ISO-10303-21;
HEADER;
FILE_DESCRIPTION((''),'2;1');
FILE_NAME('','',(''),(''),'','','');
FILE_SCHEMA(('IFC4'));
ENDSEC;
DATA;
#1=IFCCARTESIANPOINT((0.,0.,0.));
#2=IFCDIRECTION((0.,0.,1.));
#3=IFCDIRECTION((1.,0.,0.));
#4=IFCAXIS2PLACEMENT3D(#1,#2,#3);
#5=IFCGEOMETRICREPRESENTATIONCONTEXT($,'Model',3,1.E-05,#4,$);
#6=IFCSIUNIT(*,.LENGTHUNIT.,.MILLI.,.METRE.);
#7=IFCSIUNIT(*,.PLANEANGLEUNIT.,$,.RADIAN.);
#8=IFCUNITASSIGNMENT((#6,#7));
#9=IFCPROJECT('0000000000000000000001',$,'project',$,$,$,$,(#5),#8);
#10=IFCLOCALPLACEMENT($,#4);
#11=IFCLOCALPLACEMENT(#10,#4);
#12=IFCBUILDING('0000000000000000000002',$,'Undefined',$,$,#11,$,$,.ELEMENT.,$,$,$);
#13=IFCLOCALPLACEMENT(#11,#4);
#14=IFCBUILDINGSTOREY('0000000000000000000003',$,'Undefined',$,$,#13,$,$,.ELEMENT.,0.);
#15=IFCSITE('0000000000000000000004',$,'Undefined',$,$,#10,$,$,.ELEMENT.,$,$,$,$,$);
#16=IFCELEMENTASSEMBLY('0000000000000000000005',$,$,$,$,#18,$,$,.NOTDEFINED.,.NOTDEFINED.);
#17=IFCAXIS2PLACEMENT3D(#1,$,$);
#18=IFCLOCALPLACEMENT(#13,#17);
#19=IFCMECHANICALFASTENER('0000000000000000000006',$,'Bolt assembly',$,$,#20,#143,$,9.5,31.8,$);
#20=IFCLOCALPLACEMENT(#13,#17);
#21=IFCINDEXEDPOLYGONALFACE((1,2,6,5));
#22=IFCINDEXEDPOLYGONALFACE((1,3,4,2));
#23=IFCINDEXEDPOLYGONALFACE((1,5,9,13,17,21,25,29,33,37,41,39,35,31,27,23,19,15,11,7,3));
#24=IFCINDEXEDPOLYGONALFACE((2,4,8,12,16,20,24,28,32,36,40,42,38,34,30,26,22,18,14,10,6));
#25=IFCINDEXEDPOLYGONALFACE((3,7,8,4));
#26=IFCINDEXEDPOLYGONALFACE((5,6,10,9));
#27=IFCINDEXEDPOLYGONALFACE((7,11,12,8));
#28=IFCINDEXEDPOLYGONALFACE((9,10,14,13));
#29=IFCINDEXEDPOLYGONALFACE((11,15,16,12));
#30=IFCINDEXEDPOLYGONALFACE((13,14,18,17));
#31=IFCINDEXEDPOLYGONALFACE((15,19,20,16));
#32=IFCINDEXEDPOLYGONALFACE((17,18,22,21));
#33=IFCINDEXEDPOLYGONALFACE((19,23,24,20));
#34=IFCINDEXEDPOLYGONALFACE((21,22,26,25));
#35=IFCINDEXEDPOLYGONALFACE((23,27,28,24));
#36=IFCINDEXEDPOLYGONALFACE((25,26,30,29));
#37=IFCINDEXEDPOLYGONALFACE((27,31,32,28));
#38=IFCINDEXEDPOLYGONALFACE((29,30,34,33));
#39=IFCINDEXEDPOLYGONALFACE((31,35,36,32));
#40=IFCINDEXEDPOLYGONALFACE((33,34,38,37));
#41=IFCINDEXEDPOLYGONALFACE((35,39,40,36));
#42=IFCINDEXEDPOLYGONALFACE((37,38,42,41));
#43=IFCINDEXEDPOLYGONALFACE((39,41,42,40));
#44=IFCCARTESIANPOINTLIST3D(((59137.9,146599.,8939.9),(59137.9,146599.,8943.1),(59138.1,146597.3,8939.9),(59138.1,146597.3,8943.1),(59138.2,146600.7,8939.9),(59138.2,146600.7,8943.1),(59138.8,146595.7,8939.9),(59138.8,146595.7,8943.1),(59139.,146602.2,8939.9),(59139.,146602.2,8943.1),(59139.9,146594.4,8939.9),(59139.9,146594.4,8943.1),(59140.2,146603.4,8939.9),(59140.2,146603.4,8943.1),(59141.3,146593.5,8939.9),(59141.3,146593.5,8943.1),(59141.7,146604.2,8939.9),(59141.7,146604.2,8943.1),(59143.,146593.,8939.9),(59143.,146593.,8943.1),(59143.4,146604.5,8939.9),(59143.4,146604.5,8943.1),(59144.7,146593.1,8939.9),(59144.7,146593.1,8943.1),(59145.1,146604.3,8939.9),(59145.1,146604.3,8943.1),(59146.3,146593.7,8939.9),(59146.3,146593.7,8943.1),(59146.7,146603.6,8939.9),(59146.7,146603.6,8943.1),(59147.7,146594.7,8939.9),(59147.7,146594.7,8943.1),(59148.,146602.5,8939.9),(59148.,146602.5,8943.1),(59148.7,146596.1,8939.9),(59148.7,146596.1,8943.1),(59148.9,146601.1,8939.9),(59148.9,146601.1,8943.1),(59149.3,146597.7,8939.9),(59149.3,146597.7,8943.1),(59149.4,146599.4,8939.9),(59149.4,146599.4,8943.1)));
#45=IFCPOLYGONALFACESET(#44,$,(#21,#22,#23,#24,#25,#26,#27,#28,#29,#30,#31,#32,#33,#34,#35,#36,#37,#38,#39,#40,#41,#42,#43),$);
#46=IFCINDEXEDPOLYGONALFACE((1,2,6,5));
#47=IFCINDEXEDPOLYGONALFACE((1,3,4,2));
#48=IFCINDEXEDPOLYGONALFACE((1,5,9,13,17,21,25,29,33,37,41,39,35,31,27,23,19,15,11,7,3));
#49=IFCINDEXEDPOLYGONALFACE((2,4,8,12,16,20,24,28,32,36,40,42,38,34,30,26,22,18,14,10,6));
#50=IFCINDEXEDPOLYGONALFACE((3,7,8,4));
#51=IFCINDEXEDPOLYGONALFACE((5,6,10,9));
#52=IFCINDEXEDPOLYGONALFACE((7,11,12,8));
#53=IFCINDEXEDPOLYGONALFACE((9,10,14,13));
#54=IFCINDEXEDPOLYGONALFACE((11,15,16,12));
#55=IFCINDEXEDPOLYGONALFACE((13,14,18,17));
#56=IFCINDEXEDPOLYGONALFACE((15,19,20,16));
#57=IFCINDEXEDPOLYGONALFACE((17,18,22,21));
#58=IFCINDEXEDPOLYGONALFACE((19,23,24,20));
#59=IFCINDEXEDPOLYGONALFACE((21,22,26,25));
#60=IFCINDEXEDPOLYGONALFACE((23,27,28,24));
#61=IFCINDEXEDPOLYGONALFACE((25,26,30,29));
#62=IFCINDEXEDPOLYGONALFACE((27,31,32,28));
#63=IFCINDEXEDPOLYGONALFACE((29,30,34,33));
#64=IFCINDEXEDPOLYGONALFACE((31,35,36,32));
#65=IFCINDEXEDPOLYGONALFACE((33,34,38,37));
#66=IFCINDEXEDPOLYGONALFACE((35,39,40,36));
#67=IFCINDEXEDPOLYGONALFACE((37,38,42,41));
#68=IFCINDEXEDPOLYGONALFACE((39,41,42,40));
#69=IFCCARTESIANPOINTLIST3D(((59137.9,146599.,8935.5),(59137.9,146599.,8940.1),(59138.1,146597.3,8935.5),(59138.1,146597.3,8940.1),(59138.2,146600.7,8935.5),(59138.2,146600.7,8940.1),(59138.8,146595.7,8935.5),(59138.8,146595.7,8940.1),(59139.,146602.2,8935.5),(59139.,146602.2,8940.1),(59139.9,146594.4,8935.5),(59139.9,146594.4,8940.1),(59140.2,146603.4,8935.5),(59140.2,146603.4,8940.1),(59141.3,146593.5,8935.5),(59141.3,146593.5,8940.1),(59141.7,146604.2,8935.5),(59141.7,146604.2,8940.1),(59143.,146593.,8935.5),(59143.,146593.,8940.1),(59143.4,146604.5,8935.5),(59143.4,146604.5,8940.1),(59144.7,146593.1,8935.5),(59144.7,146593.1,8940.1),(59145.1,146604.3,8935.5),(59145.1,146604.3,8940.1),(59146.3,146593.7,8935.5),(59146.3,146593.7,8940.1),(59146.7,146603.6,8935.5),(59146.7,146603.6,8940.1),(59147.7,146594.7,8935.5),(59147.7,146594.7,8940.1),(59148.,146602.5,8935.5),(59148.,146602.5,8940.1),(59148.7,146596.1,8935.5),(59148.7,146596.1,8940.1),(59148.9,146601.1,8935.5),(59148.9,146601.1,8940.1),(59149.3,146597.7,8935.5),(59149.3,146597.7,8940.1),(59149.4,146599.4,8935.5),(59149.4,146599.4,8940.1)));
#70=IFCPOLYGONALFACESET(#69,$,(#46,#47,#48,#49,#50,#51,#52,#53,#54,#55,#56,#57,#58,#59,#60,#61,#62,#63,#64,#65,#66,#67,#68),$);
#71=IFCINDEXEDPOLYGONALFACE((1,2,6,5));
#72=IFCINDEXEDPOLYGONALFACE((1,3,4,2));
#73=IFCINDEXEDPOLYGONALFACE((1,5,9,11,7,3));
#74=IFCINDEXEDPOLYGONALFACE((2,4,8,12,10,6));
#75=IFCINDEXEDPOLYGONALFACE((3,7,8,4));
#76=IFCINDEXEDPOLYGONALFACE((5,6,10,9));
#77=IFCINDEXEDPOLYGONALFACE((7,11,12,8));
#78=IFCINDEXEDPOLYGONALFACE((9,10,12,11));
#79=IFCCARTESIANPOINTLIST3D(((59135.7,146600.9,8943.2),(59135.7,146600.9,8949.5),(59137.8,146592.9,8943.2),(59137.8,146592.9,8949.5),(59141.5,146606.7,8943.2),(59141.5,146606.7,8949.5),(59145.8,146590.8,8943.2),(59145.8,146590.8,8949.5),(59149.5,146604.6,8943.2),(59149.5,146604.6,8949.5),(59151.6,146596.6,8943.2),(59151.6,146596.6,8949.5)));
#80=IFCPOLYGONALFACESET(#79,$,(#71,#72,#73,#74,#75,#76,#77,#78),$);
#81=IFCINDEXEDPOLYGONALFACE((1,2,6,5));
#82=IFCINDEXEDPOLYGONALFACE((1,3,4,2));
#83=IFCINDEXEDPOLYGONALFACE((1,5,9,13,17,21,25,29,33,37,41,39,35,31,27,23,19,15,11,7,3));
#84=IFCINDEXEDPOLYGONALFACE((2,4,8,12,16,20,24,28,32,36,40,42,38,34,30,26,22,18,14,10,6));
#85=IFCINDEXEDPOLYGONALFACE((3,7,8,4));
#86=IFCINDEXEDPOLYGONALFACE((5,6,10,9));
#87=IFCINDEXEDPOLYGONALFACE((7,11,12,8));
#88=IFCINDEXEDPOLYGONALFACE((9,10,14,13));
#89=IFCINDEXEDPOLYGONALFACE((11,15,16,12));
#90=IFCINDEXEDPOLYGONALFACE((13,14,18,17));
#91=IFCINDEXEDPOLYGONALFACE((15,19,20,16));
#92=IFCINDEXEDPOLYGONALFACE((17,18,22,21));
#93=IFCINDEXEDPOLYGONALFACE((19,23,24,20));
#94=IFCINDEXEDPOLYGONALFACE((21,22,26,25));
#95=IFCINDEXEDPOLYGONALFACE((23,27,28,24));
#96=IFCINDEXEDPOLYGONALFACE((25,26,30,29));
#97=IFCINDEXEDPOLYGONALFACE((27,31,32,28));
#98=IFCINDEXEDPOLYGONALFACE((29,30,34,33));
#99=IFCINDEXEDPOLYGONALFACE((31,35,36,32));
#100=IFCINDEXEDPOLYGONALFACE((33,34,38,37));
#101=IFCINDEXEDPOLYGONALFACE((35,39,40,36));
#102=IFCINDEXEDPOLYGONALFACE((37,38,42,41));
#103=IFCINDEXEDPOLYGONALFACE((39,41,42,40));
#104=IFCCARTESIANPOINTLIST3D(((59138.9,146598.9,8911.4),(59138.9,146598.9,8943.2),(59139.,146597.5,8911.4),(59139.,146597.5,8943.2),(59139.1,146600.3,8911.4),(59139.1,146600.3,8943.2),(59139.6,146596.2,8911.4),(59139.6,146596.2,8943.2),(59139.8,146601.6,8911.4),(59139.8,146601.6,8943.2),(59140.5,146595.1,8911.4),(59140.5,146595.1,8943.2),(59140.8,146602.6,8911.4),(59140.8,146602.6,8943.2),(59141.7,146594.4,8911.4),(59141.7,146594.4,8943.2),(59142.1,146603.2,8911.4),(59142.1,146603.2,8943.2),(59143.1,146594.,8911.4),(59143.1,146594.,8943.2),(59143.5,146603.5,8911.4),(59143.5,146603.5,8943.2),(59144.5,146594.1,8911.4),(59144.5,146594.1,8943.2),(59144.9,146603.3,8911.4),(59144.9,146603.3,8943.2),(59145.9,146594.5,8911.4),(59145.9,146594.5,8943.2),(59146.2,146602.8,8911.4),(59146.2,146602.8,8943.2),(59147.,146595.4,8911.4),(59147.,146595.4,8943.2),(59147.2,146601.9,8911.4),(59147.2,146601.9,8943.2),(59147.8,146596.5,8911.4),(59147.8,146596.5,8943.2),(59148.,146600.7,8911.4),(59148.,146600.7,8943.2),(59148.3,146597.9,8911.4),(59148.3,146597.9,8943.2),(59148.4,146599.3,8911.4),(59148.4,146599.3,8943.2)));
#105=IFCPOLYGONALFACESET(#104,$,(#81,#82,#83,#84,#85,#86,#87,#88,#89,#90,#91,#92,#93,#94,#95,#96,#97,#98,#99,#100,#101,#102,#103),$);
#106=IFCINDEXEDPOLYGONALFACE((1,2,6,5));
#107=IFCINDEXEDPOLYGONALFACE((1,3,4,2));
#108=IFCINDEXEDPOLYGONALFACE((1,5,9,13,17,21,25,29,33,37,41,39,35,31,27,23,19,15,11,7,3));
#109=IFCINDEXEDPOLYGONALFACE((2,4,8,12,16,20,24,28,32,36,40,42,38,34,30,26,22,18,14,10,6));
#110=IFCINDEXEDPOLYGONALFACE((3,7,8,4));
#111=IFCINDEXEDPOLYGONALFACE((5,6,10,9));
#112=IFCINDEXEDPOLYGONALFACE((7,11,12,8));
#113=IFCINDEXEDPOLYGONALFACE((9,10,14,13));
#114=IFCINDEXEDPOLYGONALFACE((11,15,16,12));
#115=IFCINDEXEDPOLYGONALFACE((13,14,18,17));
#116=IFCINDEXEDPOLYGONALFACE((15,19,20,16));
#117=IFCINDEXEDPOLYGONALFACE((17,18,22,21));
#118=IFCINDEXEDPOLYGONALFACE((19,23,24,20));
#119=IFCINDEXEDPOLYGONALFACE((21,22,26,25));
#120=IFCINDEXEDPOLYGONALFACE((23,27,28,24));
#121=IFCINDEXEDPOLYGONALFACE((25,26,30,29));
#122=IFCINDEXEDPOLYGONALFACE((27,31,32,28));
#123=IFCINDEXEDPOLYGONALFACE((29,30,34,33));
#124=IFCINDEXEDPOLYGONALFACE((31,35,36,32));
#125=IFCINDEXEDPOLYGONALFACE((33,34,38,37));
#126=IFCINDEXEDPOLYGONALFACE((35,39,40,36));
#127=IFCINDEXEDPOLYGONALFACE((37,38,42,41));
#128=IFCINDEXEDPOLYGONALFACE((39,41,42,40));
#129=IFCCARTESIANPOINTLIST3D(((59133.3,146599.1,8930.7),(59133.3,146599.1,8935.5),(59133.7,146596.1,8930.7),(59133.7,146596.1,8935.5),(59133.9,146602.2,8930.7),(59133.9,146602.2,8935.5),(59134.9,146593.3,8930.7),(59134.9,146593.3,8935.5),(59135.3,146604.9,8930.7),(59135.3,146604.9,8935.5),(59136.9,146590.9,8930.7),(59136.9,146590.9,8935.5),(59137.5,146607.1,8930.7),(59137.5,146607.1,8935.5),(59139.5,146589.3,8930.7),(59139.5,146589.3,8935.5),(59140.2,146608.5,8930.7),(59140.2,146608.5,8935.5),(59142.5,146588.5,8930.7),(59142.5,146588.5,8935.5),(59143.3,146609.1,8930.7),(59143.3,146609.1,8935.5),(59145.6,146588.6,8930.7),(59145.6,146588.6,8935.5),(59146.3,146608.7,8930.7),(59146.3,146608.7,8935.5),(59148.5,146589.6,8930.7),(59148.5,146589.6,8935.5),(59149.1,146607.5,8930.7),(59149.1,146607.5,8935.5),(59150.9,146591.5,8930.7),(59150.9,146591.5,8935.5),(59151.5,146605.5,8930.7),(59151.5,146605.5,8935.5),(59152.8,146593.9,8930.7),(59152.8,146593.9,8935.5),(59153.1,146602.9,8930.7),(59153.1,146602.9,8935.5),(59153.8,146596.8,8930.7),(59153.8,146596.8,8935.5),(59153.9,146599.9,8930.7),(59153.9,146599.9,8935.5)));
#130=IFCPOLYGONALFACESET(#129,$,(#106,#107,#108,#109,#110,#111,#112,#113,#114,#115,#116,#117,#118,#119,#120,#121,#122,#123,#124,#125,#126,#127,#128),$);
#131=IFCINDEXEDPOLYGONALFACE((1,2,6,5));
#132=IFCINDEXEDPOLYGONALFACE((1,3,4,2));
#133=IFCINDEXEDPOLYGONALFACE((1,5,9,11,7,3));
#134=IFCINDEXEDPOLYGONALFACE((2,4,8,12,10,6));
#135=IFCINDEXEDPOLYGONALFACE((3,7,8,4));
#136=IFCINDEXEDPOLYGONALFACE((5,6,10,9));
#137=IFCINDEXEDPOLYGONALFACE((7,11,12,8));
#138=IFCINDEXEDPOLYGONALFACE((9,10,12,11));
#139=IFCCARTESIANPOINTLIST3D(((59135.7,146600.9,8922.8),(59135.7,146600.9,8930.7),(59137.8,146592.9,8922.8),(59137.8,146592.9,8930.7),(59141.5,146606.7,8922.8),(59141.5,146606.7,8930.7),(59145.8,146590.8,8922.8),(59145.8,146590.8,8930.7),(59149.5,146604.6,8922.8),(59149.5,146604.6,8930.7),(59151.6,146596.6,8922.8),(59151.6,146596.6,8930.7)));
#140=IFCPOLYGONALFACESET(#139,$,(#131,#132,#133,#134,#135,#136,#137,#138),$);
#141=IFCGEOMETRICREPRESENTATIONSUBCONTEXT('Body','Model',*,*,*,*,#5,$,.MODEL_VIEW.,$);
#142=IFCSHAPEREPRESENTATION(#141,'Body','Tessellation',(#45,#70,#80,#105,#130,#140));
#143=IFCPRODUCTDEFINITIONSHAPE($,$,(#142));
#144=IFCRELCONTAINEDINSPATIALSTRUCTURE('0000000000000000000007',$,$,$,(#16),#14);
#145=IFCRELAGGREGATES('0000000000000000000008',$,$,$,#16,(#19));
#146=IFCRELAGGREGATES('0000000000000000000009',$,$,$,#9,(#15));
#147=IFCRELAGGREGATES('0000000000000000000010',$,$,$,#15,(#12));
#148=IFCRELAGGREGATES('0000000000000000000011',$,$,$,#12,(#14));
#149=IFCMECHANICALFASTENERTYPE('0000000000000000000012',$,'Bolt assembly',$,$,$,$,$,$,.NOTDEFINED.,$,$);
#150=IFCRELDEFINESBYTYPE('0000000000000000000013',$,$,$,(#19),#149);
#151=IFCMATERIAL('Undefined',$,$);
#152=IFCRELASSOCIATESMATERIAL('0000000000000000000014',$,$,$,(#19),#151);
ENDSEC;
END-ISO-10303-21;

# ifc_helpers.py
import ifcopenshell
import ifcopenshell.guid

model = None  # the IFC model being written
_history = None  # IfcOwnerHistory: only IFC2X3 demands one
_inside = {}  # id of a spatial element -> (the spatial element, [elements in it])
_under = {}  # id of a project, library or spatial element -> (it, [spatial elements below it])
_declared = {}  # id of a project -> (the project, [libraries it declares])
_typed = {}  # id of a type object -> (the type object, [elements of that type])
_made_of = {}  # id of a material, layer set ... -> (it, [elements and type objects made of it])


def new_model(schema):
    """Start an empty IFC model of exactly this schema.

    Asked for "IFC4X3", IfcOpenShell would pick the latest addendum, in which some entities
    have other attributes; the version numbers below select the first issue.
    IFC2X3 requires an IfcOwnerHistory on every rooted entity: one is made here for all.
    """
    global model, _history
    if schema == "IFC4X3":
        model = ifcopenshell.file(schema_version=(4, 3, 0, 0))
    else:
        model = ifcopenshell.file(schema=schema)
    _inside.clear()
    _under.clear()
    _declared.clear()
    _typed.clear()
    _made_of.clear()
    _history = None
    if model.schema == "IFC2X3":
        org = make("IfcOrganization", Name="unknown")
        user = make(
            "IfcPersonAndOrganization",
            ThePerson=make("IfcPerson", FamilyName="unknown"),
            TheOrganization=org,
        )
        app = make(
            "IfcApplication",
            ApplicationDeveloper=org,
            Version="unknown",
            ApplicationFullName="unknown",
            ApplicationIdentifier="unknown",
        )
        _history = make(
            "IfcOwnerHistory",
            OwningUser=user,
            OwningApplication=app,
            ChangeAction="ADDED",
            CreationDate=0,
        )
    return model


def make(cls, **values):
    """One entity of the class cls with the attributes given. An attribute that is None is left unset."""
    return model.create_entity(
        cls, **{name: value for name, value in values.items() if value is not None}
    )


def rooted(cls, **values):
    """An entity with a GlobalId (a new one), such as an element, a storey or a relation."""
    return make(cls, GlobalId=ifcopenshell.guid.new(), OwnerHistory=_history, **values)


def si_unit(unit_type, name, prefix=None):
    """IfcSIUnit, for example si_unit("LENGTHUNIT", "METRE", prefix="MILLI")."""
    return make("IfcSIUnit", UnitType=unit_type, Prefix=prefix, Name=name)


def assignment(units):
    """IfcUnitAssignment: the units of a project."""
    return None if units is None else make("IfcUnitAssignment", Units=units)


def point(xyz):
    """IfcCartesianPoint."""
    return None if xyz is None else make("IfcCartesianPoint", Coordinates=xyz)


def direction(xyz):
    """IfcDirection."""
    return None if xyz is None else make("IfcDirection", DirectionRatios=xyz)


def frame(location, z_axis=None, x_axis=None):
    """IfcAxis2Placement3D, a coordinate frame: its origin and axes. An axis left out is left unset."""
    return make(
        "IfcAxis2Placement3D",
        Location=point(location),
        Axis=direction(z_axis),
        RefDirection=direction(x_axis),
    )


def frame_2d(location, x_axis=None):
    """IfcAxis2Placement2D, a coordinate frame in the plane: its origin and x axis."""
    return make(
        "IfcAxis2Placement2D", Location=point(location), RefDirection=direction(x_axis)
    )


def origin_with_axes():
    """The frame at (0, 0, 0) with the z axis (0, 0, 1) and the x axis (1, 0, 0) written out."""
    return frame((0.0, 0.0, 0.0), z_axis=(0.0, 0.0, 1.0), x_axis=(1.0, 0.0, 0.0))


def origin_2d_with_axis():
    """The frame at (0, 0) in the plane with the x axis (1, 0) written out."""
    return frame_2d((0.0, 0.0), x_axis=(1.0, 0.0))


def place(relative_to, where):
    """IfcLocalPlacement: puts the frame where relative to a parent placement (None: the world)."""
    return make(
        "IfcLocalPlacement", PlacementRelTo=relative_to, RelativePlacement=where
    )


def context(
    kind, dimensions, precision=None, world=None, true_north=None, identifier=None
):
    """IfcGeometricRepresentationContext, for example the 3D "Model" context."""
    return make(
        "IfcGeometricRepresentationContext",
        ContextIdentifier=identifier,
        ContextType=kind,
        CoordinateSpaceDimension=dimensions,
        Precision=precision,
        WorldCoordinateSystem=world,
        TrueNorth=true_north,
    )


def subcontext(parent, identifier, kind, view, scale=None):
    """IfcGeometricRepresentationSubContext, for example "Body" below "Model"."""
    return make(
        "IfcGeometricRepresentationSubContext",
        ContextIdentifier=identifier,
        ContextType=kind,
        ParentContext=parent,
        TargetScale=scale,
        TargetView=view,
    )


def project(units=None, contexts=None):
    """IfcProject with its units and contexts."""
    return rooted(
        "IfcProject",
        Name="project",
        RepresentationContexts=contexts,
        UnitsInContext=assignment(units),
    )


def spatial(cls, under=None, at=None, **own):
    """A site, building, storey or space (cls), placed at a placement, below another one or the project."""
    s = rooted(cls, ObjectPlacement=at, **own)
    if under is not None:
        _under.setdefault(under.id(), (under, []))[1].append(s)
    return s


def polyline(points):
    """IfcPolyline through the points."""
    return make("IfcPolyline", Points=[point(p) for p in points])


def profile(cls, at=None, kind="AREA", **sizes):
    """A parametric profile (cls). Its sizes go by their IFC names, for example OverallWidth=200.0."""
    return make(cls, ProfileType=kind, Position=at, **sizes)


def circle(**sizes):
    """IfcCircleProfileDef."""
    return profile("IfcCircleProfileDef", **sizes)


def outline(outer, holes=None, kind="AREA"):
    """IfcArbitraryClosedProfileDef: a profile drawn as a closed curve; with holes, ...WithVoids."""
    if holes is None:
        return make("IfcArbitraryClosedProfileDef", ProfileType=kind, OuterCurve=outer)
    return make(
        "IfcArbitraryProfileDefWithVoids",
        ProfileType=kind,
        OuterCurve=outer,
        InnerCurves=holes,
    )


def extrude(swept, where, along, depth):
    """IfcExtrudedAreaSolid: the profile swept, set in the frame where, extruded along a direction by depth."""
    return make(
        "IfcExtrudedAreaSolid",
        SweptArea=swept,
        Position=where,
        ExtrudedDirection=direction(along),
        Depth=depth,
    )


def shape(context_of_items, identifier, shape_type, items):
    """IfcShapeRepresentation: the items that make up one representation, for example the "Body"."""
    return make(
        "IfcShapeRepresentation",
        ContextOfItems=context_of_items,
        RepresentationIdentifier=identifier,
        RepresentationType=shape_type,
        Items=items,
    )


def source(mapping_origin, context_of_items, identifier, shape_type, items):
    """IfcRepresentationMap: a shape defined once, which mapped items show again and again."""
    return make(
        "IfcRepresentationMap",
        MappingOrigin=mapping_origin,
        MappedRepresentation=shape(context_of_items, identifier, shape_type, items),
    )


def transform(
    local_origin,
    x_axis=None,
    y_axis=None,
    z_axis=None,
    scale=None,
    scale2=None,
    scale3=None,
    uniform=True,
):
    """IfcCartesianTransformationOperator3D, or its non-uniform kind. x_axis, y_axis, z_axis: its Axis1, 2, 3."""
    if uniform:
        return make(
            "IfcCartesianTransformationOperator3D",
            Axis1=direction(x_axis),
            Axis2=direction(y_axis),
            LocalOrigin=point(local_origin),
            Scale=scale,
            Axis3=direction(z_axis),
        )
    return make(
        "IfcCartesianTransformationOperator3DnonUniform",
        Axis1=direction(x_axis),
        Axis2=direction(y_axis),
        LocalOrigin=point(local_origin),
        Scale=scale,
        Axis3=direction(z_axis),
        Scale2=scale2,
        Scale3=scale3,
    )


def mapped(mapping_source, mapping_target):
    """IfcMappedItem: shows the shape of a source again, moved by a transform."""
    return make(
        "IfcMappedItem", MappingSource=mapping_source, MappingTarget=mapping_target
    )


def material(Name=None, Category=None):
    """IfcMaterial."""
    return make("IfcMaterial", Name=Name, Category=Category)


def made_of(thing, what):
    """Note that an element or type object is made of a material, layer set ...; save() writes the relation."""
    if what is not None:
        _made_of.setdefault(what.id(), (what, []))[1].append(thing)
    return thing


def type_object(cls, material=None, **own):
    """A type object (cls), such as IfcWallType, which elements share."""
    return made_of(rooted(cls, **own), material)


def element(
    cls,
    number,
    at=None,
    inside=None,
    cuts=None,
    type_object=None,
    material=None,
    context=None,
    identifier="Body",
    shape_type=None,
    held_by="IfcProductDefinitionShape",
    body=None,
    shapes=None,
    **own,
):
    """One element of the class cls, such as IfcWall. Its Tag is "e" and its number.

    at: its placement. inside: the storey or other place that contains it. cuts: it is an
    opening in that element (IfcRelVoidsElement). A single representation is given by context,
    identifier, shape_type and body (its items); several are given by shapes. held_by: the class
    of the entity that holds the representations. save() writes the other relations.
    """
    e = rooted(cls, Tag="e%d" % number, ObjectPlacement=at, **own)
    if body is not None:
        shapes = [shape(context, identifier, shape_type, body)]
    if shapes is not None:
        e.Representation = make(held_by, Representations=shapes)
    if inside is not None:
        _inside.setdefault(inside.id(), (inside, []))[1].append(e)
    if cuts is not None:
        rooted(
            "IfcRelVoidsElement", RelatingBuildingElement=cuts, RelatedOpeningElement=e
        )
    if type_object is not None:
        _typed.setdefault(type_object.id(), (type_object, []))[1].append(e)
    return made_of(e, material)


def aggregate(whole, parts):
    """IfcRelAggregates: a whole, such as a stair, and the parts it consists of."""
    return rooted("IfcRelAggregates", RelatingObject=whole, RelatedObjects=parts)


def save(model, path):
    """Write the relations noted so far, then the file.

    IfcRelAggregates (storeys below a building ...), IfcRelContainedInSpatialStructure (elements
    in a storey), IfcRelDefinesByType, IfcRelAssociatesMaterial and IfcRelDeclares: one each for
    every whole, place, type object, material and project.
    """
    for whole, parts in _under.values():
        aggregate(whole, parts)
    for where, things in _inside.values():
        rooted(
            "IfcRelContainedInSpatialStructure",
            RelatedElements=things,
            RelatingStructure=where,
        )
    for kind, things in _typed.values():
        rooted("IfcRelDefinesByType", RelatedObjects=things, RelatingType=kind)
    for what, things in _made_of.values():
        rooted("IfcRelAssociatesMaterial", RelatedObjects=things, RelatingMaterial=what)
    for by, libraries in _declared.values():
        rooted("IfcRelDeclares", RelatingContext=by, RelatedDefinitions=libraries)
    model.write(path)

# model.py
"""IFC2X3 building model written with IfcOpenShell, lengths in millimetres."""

from ifc_helpers import new_model, si_unit, frame, origin_with_axes, origin_2d_with_axis, place, context, subcontext, project, spatial, polyline, circle, outline, extrude, source, transform, mapped, material, type_object, element, aggregate, save


model = new_model("IFC2X3")

# Units and contexts
model_context = context("Model", 3, precision=1e-05, world=origin_with_axes())
body_context = subcontext(model_context, "Body", "Model", "MODEL_VIEW")
ifc_project = project(units=[si_unit("LENGTHUNIT", "METRE", prefix="MILLI"), si_unit("PLANEANGLEUNIT", "RADIAN")], contexts=[model_context])

# Site, building, storey
site_placement = place(None, origin_with_axes())
site = spatial("IfcSite", under=ifc_project, at=site_placement, Name="Undefined", CompositionType="ELEMENT")
building_placement = place(site_placement, origin_with_axes())
building = spatial("IfcBuilding", under=site, at=building_placement, Name="Undefined", CompositionType="ELEMENT")
storey_placement = place(building_placement, origin_with_axes())
storey = spatial("IfcBuildingStorey", under=building, at=storey_placement, Name="Undefined", CompositionType="ELEMENT", Elevation=0.0)

# Element assembly
assembly_1_placement = place(storey_placement, origin_with_axes())
assembly_1 = element("IfcElementAssembly", 1, at=assembly_1_placement, inside=storey, AssemblyPlace="NOTDEFINED", PredefinedType="NOTDEFINED")

# Mechanical fastener
ifc_material_1 = material(Name="Undefined")
mechanical_fastener_type = type_object("IfcMechanicalFastenerType", Name="Bolt assembly")
shared_shape_1 = source(origin_with_axes(), body_context, "Body", "SweptSolid", [
    extrude(circle(Radius=5.8, at=origin_2d_with_axis()), frame((0.0, -7.6, 0.0), z_axis=(0.0, 1.0, 0.0), x_axis=(1.0, 0.0, 0.0)), (0.0, 0.0, 1.0), 3.2),
    extrude(circle(Radius=5.8, at=origin_2d_with_axis()), frame((0.0, -4.6, 0.0), z_axis=(0.0, 1.0, 0.0), x_axis=(1.0, 0.0, 0.0)), (0.0, 0.0, 1.0), 4.6),
    extrude(outline(polyline([(7.1, -4.1), (7.1, 4.1), (0.0, 8.2), (-7.1, 4.1), (-7.1, -4.1), (0.0, -8.2), (7.1, -4.1)])), frame((0.0, -14.0, 0.0), z_axis=(0.0, 1.0, 0.0), x_axis=(1.0, 0.0, 0.0)), (0.0, 0.0, 1.0), 6.3),
    extrude(circle(Radius=4.8, at=origin_2d_with_axis()), frame((0.0, -7.7, 0.0), z_axis=(0.0, 1.0, 0.0), x_axis=(1.0, 0.0, 0.0)), (0.0, 0.0, 1.0), 31.8),
    extrude(circle(Radius=10.3, at=origin_2d_with_axis()), frame((0.0, 0.0, 0.0), z_axis=(0.0, 1.0, 0.0), x_axis=(1.0, 0.0, 0.0)), (0.0, 0.0, 1.0), 4.8),
    extrude(outline(polyline([(7.1, -4.1), (7.1, 4.1), (0.0, 8.2), (-7.1, 4.1), (-7.1, -4.1), (0.0, -8.2), (7.1, -4.1)])), frame((0.0, 4.8, 0.0), z_axis=(0.0, 1.0, 0.0), x_axis=(1.0, 0.0, 0.0)), (0.0, 0.0, 1.0), 7.9),
])
mechanical_fastener_1_placement = place(assembly_1_placement, frame((59143.6, 146598.7, 8935.5), z_axis=(0.707107, 0.707107, 0.0), x_axis=(0.707107, -0.707107, 0.0)))
mechanical_fastener_1 = element("IfcMechanicalFastener", 2, at=mechanical_fastener_1_placement, type_object=mechanical_fastener_type, material=ifc_material_1, Name="Bolt assembly", NominalDiameter=9.5, NominalLength=31.8, context=body_context, shape_type="MappedRepresentation", body=[
    mapped(shared_shape_1, transform((0.0, 0.0, 0.0))),
])
aggregate(assembly_1, [mechanical_fastener_1])

save(model, "model.ifc")
